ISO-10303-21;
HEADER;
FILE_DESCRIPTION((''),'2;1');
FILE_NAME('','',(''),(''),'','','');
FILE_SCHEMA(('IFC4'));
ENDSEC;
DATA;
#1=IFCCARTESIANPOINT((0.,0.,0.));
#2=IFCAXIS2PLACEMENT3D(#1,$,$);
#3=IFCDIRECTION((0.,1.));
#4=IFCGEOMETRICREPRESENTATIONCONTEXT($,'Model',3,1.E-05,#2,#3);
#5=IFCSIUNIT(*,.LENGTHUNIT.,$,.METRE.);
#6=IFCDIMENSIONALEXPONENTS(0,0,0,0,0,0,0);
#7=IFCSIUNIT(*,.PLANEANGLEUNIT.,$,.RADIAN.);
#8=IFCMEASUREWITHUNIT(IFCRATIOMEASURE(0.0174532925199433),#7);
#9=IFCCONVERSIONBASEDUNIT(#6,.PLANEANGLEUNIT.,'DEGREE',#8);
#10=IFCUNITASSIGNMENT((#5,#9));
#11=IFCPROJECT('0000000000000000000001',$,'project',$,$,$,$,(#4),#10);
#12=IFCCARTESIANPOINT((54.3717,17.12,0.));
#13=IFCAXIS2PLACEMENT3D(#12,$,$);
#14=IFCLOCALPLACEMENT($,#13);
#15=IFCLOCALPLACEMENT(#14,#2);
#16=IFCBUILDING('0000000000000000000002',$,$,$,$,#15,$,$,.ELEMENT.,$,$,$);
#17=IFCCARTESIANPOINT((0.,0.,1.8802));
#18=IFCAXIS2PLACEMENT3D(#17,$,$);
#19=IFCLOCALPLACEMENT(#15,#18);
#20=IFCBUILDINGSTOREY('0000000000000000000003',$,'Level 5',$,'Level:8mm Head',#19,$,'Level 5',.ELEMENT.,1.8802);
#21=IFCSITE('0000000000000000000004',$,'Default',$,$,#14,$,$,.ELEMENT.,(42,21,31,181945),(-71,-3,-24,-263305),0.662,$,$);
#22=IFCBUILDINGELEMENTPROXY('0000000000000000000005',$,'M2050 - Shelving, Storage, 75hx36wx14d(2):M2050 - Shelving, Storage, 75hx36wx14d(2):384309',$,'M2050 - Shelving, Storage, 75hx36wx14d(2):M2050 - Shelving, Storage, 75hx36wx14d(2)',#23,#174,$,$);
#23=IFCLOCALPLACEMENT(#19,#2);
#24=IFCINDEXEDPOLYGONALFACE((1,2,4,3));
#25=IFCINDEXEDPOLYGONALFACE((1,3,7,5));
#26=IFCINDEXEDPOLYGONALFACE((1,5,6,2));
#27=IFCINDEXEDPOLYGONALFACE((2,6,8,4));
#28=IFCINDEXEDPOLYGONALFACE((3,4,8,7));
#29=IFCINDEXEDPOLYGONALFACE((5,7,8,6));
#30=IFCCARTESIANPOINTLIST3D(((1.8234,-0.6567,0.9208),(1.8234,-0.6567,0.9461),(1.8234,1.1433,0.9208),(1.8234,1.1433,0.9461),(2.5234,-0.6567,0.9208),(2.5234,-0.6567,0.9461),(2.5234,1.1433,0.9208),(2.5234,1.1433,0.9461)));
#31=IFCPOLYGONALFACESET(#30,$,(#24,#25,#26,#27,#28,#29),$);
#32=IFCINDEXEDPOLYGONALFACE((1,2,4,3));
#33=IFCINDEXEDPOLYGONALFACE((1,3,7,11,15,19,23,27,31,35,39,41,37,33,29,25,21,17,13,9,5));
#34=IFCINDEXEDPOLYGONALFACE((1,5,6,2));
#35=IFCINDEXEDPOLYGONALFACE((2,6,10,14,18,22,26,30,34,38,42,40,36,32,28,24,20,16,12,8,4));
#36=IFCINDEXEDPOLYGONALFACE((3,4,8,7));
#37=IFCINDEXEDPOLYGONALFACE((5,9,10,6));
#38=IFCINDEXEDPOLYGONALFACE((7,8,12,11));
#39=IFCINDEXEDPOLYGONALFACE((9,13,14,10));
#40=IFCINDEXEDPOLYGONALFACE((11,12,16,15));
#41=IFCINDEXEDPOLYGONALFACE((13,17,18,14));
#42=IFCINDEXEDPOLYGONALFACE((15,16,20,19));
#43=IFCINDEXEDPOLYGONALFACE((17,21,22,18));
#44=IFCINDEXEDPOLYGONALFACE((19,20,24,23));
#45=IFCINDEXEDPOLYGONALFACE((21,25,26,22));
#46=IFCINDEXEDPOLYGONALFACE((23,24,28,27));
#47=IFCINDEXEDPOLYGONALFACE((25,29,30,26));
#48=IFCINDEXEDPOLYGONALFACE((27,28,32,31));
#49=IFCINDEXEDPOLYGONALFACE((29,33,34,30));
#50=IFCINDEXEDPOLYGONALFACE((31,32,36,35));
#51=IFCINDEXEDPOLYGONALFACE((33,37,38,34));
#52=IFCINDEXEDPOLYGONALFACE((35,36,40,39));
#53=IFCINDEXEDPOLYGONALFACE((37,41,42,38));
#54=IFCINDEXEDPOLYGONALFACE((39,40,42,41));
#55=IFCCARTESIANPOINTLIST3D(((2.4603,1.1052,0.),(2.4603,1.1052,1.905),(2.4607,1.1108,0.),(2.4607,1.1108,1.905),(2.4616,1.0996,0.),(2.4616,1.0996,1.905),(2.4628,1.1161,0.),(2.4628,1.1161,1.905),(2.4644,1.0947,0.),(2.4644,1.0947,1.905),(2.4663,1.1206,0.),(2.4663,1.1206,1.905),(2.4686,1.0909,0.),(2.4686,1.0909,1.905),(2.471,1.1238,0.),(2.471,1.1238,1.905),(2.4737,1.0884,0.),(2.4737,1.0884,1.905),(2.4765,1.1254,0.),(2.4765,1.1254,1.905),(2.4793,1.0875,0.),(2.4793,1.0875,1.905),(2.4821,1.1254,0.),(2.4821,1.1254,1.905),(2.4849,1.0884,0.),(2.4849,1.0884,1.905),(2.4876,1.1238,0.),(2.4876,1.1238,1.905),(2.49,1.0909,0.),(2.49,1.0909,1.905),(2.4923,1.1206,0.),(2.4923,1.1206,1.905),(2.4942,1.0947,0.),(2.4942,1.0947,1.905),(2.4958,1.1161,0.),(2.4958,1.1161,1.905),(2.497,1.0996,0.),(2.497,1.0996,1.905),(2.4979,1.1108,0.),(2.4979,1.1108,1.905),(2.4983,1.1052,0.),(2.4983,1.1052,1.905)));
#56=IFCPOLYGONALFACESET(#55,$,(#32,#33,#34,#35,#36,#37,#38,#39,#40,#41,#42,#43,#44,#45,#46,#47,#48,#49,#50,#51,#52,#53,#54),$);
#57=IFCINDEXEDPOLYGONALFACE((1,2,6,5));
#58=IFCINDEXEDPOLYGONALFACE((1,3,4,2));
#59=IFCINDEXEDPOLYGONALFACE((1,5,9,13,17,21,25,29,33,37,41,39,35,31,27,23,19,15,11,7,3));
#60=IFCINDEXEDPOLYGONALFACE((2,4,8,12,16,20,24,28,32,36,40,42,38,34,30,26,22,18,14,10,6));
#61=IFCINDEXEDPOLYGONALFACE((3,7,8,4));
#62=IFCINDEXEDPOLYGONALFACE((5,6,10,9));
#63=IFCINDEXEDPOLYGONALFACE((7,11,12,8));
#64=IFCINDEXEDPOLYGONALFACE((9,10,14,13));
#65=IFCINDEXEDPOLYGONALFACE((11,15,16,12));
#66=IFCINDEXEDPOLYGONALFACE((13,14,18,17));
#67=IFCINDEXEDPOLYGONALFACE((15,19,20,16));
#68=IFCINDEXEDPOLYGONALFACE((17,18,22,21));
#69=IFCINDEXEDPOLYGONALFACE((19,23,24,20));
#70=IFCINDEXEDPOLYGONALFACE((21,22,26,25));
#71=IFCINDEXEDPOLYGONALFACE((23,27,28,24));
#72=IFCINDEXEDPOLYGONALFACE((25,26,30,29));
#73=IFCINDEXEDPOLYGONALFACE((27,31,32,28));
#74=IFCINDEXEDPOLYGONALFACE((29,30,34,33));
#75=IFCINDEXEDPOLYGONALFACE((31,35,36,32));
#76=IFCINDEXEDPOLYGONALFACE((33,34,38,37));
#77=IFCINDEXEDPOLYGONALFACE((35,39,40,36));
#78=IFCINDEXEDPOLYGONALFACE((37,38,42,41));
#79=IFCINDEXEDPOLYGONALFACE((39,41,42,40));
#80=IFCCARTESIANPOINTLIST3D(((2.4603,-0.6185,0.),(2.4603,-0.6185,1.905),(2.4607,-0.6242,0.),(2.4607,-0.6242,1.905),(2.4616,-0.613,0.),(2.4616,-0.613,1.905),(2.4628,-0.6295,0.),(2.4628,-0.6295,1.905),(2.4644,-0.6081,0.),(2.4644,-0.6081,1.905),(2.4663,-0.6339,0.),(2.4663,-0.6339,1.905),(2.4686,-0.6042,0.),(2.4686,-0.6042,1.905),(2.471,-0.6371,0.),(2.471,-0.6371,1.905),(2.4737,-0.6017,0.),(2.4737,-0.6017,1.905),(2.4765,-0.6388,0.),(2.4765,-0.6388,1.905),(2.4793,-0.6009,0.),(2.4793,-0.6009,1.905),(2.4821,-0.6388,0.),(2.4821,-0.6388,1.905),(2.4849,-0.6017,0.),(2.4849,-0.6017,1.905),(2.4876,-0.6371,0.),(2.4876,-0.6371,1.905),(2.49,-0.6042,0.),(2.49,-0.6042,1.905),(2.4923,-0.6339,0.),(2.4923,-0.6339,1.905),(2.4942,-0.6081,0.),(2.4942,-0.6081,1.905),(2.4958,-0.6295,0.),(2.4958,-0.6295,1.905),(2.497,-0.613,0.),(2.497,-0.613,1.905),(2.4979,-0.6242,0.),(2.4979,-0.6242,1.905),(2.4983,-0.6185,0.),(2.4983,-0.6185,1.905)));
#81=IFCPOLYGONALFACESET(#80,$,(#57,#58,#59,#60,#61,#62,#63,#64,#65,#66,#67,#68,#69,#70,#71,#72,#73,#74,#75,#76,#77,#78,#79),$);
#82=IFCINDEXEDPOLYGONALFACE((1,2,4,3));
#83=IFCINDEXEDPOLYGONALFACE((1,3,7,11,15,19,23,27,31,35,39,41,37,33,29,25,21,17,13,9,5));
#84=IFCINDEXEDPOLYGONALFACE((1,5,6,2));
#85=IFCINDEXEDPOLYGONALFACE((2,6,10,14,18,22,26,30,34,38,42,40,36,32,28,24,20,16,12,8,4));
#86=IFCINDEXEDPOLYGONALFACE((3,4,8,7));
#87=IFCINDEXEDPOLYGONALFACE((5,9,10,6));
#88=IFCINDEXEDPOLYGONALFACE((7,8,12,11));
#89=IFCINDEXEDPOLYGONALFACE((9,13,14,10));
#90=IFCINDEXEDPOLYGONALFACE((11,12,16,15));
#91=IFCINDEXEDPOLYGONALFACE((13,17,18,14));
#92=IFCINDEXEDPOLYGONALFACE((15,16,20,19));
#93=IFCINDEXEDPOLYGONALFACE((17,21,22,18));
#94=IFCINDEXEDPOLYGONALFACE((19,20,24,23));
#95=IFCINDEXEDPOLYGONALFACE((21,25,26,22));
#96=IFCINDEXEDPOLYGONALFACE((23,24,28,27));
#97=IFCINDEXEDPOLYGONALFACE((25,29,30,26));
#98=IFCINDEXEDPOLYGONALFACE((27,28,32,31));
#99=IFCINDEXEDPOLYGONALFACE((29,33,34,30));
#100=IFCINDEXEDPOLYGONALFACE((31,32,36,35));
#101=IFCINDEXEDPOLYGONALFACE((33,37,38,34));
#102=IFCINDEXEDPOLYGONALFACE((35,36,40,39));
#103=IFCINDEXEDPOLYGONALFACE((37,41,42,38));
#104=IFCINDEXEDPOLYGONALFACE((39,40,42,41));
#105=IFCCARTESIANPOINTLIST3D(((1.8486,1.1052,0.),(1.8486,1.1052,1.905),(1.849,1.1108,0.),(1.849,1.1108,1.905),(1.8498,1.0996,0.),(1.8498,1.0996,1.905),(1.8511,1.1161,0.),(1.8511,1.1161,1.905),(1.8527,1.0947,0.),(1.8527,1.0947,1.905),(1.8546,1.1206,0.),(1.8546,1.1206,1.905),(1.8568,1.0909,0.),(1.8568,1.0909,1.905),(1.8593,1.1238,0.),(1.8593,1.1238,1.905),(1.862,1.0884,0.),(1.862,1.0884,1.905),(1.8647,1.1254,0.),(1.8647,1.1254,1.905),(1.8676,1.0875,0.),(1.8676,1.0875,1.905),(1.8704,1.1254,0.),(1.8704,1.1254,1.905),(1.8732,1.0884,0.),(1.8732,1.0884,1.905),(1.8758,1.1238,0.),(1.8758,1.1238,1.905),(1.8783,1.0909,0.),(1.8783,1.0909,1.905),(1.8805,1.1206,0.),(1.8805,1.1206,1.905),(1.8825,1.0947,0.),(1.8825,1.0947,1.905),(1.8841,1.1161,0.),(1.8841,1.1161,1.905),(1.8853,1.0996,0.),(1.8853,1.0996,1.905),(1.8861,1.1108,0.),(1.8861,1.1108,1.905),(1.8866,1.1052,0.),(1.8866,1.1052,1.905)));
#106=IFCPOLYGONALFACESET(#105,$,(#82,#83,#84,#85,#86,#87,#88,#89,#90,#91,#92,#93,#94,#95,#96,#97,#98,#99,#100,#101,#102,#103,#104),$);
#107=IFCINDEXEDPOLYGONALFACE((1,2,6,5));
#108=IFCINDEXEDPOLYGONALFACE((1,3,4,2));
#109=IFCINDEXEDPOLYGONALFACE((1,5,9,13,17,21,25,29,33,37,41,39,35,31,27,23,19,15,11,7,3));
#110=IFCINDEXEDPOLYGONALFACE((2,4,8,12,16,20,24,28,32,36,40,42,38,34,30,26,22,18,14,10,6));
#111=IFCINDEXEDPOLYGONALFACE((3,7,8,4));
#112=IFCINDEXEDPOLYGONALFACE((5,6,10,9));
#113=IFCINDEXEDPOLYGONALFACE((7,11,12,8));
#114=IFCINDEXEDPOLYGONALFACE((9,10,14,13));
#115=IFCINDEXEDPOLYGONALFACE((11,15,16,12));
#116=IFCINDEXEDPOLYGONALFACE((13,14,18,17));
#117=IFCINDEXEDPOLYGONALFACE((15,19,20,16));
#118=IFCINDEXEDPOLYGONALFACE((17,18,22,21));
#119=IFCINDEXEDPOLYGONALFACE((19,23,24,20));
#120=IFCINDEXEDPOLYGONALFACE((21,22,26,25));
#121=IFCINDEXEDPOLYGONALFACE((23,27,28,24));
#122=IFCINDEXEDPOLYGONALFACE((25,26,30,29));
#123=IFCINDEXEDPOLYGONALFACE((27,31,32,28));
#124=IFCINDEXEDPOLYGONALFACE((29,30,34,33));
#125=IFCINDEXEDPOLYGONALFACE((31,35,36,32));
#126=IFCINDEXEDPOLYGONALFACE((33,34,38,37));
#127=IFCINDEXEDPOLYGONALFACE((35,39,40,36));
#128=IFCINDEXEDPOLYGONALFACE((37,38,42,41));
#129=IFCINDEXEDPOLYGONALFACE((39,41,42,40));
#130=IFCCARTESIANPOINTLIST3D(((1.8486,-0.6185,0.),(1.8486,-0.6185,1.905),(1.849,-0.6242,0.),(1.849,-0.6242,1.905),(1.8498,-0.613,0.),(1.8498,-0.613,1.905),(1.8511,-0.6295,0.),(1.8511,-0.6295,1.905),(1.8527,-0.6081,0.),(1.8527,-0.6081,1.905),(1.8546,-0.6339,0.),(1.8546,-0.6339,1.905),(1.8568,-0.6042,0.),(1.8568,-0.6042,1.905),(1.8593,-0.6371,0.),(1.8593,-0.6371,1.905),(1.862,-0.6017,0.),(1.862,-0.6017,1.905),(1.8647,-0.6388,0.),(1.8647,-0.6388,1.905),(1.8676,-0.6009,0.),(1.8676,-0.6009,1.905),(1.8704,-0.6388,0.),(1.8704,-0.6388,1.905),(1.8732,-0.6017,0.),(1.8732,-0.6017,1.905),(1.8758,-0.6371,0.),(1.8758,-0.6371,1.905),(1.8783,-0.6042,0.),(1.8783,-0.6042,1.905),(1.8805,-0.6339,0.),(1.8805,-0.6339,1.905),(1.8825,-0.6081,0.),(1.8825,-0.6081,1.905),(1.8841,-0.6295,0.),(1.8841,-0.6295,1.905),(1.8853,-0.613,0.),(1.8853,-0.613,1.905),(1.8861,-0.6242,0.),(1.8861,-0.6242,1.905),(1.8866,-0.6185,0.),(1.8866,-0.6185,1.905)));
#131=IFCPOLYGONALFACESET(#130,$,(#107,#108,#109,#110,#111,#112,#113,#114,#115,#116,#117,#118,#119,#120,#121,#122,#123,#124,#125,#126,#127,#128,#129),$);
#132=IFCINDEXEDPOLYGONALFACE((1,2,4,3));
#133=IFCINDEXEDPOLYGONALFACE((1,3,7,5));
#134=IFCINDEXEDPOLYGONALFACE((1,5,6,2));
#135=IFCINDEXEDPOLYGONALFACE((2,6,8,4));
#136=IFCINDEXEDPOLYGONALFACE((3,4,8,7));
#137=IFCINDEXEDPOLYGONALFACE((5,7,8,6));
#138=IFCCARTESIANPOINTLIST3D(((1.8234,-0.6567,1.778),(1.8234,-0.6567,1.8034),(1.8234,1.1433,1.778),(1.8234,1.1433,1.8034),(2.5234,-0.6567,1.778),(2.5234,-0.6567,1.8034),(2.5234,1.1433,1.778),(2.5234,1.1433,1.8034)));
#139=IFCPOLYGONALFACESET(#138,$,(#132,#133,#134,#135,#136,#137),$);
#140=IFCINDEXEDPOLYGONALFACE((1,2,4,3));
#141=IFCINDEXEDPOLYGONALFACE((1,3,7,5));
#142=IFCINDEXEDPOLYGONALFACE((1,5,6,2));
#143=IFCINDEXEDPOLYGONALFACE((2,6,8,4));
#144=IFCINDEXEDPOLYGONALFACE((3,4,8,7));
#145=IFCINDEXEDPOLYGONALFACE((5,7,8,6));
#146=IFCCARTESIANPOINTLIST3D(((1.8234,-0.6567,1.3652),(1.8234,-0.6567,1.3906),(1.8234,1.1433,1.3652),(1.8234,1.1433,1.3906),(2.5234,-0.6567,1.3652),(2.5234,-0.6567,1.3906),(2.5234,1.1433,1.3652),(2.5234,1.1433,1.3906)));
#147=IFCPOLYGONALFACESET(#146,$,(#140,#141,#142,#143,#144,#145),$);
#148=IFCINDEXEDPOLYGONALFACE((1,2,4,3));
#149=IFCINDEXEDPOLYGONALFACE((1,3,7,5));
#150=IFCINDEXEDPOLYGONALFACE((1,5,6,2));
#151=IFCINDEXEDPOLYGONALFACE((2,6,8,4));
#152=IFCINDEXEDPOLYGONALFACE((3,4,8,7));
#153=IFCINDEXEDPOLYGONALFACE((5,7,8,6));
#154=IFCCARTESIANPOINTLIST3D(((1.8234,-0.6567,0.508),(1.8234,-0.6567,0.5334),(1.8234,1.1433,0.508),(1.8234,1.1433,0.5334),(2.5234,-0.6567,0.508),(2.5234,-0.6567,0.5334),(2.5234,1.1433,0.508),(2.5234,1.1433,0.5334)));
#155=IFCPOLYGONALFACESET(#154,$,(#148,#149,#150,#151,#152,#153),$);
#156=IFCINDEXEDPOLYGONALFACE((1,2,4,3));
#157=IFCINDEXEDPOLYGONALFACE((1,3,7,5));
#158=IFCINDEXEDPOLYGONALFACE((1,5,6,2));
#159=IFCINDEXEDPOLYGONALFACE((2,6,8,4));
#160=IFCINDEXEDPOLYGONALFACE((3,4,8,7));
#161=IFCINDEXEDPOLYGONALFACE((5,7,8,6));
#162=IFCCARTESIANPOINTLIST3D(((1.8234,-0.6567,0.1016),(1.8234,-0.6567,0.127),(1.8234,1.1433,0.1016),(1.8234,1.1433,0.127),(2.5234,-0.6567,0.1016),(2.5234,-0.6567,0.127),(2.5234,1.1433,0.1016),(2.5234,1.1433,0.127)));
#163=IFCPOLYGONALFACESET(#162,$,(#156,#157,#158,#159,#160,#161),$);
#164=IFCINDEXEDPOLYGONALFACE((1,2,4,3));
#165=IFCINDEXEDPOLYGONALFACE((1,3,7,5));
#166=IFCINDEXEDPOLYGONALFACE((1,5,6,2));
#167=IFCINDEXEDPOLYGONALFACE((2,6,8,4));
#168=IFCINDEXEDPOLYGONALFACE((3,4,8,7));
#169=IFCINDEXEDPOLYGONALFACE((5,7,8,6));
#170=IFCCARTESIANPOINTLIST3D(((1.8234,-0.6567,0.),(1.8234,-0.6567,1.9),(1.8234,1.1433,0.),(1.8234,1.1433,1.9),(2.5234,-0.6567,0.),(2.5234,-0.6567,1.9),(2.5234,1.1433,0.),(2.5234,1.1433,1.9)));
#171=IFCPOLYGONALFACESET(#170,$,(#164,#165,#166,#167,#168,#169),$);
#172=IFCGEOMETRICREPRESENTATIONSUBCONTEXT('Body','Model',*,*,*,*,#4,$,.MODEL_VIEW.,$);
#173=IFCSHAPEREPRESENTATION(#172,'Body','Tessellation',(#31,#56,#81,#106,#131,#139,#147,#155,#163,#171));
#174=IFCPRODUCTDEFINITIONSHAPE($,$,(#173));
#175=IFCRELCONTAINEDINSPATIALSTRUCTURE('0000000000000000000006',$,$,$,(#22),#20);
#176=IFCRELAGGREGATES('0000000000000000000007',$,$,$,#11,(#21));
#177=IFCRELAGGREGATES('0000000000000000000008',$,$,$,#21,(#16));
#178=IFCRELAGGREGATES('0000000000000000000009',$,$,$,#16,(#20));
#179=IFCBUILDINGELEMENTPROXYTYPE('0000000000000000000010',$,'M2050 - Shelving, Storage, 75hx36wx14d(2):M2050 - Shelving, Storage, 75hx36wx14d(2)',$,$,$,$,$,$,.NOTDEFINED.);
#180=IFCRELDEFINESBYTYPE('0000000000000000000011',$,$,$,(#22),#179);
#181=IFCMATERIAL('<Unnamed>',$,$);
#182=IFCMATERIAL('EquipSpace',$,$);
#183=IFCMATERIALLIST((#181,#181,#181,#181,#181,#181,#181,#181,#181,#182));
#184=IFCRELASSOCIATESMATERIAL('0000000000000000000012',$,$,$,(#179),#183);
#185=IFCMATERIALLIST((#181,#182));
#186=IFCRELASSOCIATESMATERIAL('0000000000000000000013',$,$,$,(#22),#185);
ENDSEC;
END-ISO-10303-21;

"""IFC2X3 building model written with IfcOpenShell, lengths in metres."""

from ifc_helpers import new_model, entity, si_unit, converted_unit, direction, frame, frame_2d, origin, origin_2d_with_axis, place, context, subcontext, project, spatial, rectangle, circle, extrude, source, transform, mapped, material, material_list, type_object, type_shapes, element, save


model = new_model("IFC2X3")

# Units and contexts
model_context = context("Model", 3, precision=1e-05, world=origin(), true_north=direction((0.0, 1.0)))
body_context = subcontext(model_context, "Body", "Model", "MODEL_VIEW")
ifc_project = project(units=[si_unit("LENGTHUNIT", "METRE"), converted_unit("PLANEANGLEUNIT", "DEGREE", entity("IfcRatioMeasure", 0.0174532925199433), si_unit("PLANEANGLEUNIT", "RADIAN"), dimensions=[0, 0, 0, 0, 0, 0, 0])], contexts=[model_context])

# Site, building, storey
site_placement = place(None, frame((54.3717, 17.12, 0.0)))
site = spatial("IfcSite", under=ifc_project, at=site_placement, Name="Default", CompositionType="ELEMENT", RefLatitude=(42, 21, 31, 181945), RefLongitude=(-71, -3, -24, -263305), RefElevation=0.662)
building_placement = place(site_placement, origin())
building = spatial("IfcBuilding", under=site, at=building_placement, CompositionType="ELEMENT")
storey_placement = place(building_placement, frame((0.0, 0.0, 1.8802)))
storey = spatial("IfcBuildingStorey", under=building, at=storey_placement, Name="Level 5", ObjectType="Level:8mm Head", LongName="Level 5", CompositionType="ELEMENT", Elevation=1.8802)

# Building element proxy
ifc_material_1 = material(Name="<Unnamed>")
ifc_material_2 = material(Name="EquipSpace")
ifc_material_list_1 = material_list([ifc_material_1, ifc_material_2])
ifc_material_list_2 = material_list([ifc_material_1, ifc_material_1, ifc_material_1, ifc_material_1, ifc_material_1, ifc_material_1, ifc_material_1, ifc_material_1, ifc_material_1, ifc_material_2])
building_element_proxy_type = type_object("IfcBuildingElementProxyType", Name="M2050 - Shelving, Storage, 75hx36wx14d(2):M2050 - Shelving, Storage, 75hx36wx14d(2)", PredefinedType="NOTDEFINED", material=ifc_material_list_2)
shared_shape = source(origin(), body_context, "Body", "SweptSolid", [
    extrude(rectangle(XDim=1.8, YDim=0.7, at=origin_2d_with_axis()), frame((0.0, 0.0, 0.9207), z_axis=(0.0, 0.0, 1.0), x_axis=(-1.0, 0.0, 0.0)), (0.0, 0.0, 1.0), 0.0254),
    extrude(circle(Radius=0.0191, at=origin_2d_with_axis()), frame((0.8633, -0.3059, 0.0), z_axis=(0.0, 0.0, 1.0), x_axis=(-1.0, 0.0, 0.0)), (0.0, 0.0, 1.0), 1.905),
    extrude(circle(Radius=0.0191, at=origin_2d_with_axis()), frame((-0.8633, -0.3059, 0.0)), (0.0, 0.0, 1.0), 1.905),
    extrude(circle(Radius=0.0191, at=origin_2d_with_axis()), frame((0.8633, 0.3059, 0.0), z_axis=(0.0, 0.0, 1.0), x_axis=(-1.0, 0.0, 0.0)), (0.0, 0.0, 1.0), 1.905),
    extrude(circle(Radius=0.0191, at=origin_2d_with_axis()), frame((-0.8633, 0.3059, 0.0)), (0.0, 0.0, 1.0), 1.905),
    extrude(rectangle(XDim=1.8, YDim=0.7, at=origin_2d_with_axis()), frame((0.0, 0.0, 1.778), z_axis=(0.0, 0.0, 1.0), x_axis=(-1.0, 0.0, 0.0)), (0.0, 0.0, 1.0), 0.0254),
    extrude(rectangle(XDim=1.8, YDim=0.7, at=origin_2d_with_axis()), frame((0.0, 0.0, 1.3653), z_axis=(0.0, 0.0, 1.0), x_axis=(-1.0, 0.0, 0.0)), (0.0, 0.0, 1.0), 0.0254),
    extrude(rectangle(XDim=1.8, YDim=0.7, at=origin_2d_with_axis()), frame((0.0, 0.0, 0.508), z_axis=(0.0, 0.0, 1.0), x_axis=(-1.0, 0.0, 0.0)), (0.0, 0.0, 1.0), 0.0254),
    extrude(rectangle(XDim=1.8, YDim=0.7, at=origin_2d_with_axis()), frame((0.0, 0.0, 0.1016), z_axis=(0.0, 0.0, 1.0), x_axis=(-1.0, 0.0, 0.0)), (0.0, 0.0, 1.0), 0.0254),
    extrude(rectangle(XDim=0.7, YDim=1.8, at=frame_2d((0.0, 0.18), x_axis=(1.0, 0.0))), frame((-0.18, 0.0, 0.0), z_axis=(0.0, 0.0, 1.0), x_axis=(0.0, -1.0, 0.0)), (0.0, 0.0, 1.0), 1.9),
])
type_shapes(building_element_proxy_type, [shared_shape])
proxy_1_placement = place(storey_placement, frame((2.1734, 0.2433, 0.0), z_axis=(0.0, 0.0, 1.0), x_axis=(0.0, 1.0, 0.0)))
element("IfcBuildingElementProxy", 1, at=proxy_1_placement, inside=storey, type_object=building_element_proxy_type, material=ifc_material_list_1, Name="M2050 - Shelving, Storage, 75hx36wx14d(2):M2050 - Shelving, Storage, 75hx36wx14d(2):384309", ObjectType="M2050 - Shelving, Storage, 75hx36wx14d(2):M2050 - Shelving, Storage, 75hx36wx14d(2)", context=body_context, shape_type="MappedRepresentation", body=[
    mapped(shared_shape, transform((0.0, 0.0, 0.0), scale=1.0)),
])

save(model, "model.ifc")
